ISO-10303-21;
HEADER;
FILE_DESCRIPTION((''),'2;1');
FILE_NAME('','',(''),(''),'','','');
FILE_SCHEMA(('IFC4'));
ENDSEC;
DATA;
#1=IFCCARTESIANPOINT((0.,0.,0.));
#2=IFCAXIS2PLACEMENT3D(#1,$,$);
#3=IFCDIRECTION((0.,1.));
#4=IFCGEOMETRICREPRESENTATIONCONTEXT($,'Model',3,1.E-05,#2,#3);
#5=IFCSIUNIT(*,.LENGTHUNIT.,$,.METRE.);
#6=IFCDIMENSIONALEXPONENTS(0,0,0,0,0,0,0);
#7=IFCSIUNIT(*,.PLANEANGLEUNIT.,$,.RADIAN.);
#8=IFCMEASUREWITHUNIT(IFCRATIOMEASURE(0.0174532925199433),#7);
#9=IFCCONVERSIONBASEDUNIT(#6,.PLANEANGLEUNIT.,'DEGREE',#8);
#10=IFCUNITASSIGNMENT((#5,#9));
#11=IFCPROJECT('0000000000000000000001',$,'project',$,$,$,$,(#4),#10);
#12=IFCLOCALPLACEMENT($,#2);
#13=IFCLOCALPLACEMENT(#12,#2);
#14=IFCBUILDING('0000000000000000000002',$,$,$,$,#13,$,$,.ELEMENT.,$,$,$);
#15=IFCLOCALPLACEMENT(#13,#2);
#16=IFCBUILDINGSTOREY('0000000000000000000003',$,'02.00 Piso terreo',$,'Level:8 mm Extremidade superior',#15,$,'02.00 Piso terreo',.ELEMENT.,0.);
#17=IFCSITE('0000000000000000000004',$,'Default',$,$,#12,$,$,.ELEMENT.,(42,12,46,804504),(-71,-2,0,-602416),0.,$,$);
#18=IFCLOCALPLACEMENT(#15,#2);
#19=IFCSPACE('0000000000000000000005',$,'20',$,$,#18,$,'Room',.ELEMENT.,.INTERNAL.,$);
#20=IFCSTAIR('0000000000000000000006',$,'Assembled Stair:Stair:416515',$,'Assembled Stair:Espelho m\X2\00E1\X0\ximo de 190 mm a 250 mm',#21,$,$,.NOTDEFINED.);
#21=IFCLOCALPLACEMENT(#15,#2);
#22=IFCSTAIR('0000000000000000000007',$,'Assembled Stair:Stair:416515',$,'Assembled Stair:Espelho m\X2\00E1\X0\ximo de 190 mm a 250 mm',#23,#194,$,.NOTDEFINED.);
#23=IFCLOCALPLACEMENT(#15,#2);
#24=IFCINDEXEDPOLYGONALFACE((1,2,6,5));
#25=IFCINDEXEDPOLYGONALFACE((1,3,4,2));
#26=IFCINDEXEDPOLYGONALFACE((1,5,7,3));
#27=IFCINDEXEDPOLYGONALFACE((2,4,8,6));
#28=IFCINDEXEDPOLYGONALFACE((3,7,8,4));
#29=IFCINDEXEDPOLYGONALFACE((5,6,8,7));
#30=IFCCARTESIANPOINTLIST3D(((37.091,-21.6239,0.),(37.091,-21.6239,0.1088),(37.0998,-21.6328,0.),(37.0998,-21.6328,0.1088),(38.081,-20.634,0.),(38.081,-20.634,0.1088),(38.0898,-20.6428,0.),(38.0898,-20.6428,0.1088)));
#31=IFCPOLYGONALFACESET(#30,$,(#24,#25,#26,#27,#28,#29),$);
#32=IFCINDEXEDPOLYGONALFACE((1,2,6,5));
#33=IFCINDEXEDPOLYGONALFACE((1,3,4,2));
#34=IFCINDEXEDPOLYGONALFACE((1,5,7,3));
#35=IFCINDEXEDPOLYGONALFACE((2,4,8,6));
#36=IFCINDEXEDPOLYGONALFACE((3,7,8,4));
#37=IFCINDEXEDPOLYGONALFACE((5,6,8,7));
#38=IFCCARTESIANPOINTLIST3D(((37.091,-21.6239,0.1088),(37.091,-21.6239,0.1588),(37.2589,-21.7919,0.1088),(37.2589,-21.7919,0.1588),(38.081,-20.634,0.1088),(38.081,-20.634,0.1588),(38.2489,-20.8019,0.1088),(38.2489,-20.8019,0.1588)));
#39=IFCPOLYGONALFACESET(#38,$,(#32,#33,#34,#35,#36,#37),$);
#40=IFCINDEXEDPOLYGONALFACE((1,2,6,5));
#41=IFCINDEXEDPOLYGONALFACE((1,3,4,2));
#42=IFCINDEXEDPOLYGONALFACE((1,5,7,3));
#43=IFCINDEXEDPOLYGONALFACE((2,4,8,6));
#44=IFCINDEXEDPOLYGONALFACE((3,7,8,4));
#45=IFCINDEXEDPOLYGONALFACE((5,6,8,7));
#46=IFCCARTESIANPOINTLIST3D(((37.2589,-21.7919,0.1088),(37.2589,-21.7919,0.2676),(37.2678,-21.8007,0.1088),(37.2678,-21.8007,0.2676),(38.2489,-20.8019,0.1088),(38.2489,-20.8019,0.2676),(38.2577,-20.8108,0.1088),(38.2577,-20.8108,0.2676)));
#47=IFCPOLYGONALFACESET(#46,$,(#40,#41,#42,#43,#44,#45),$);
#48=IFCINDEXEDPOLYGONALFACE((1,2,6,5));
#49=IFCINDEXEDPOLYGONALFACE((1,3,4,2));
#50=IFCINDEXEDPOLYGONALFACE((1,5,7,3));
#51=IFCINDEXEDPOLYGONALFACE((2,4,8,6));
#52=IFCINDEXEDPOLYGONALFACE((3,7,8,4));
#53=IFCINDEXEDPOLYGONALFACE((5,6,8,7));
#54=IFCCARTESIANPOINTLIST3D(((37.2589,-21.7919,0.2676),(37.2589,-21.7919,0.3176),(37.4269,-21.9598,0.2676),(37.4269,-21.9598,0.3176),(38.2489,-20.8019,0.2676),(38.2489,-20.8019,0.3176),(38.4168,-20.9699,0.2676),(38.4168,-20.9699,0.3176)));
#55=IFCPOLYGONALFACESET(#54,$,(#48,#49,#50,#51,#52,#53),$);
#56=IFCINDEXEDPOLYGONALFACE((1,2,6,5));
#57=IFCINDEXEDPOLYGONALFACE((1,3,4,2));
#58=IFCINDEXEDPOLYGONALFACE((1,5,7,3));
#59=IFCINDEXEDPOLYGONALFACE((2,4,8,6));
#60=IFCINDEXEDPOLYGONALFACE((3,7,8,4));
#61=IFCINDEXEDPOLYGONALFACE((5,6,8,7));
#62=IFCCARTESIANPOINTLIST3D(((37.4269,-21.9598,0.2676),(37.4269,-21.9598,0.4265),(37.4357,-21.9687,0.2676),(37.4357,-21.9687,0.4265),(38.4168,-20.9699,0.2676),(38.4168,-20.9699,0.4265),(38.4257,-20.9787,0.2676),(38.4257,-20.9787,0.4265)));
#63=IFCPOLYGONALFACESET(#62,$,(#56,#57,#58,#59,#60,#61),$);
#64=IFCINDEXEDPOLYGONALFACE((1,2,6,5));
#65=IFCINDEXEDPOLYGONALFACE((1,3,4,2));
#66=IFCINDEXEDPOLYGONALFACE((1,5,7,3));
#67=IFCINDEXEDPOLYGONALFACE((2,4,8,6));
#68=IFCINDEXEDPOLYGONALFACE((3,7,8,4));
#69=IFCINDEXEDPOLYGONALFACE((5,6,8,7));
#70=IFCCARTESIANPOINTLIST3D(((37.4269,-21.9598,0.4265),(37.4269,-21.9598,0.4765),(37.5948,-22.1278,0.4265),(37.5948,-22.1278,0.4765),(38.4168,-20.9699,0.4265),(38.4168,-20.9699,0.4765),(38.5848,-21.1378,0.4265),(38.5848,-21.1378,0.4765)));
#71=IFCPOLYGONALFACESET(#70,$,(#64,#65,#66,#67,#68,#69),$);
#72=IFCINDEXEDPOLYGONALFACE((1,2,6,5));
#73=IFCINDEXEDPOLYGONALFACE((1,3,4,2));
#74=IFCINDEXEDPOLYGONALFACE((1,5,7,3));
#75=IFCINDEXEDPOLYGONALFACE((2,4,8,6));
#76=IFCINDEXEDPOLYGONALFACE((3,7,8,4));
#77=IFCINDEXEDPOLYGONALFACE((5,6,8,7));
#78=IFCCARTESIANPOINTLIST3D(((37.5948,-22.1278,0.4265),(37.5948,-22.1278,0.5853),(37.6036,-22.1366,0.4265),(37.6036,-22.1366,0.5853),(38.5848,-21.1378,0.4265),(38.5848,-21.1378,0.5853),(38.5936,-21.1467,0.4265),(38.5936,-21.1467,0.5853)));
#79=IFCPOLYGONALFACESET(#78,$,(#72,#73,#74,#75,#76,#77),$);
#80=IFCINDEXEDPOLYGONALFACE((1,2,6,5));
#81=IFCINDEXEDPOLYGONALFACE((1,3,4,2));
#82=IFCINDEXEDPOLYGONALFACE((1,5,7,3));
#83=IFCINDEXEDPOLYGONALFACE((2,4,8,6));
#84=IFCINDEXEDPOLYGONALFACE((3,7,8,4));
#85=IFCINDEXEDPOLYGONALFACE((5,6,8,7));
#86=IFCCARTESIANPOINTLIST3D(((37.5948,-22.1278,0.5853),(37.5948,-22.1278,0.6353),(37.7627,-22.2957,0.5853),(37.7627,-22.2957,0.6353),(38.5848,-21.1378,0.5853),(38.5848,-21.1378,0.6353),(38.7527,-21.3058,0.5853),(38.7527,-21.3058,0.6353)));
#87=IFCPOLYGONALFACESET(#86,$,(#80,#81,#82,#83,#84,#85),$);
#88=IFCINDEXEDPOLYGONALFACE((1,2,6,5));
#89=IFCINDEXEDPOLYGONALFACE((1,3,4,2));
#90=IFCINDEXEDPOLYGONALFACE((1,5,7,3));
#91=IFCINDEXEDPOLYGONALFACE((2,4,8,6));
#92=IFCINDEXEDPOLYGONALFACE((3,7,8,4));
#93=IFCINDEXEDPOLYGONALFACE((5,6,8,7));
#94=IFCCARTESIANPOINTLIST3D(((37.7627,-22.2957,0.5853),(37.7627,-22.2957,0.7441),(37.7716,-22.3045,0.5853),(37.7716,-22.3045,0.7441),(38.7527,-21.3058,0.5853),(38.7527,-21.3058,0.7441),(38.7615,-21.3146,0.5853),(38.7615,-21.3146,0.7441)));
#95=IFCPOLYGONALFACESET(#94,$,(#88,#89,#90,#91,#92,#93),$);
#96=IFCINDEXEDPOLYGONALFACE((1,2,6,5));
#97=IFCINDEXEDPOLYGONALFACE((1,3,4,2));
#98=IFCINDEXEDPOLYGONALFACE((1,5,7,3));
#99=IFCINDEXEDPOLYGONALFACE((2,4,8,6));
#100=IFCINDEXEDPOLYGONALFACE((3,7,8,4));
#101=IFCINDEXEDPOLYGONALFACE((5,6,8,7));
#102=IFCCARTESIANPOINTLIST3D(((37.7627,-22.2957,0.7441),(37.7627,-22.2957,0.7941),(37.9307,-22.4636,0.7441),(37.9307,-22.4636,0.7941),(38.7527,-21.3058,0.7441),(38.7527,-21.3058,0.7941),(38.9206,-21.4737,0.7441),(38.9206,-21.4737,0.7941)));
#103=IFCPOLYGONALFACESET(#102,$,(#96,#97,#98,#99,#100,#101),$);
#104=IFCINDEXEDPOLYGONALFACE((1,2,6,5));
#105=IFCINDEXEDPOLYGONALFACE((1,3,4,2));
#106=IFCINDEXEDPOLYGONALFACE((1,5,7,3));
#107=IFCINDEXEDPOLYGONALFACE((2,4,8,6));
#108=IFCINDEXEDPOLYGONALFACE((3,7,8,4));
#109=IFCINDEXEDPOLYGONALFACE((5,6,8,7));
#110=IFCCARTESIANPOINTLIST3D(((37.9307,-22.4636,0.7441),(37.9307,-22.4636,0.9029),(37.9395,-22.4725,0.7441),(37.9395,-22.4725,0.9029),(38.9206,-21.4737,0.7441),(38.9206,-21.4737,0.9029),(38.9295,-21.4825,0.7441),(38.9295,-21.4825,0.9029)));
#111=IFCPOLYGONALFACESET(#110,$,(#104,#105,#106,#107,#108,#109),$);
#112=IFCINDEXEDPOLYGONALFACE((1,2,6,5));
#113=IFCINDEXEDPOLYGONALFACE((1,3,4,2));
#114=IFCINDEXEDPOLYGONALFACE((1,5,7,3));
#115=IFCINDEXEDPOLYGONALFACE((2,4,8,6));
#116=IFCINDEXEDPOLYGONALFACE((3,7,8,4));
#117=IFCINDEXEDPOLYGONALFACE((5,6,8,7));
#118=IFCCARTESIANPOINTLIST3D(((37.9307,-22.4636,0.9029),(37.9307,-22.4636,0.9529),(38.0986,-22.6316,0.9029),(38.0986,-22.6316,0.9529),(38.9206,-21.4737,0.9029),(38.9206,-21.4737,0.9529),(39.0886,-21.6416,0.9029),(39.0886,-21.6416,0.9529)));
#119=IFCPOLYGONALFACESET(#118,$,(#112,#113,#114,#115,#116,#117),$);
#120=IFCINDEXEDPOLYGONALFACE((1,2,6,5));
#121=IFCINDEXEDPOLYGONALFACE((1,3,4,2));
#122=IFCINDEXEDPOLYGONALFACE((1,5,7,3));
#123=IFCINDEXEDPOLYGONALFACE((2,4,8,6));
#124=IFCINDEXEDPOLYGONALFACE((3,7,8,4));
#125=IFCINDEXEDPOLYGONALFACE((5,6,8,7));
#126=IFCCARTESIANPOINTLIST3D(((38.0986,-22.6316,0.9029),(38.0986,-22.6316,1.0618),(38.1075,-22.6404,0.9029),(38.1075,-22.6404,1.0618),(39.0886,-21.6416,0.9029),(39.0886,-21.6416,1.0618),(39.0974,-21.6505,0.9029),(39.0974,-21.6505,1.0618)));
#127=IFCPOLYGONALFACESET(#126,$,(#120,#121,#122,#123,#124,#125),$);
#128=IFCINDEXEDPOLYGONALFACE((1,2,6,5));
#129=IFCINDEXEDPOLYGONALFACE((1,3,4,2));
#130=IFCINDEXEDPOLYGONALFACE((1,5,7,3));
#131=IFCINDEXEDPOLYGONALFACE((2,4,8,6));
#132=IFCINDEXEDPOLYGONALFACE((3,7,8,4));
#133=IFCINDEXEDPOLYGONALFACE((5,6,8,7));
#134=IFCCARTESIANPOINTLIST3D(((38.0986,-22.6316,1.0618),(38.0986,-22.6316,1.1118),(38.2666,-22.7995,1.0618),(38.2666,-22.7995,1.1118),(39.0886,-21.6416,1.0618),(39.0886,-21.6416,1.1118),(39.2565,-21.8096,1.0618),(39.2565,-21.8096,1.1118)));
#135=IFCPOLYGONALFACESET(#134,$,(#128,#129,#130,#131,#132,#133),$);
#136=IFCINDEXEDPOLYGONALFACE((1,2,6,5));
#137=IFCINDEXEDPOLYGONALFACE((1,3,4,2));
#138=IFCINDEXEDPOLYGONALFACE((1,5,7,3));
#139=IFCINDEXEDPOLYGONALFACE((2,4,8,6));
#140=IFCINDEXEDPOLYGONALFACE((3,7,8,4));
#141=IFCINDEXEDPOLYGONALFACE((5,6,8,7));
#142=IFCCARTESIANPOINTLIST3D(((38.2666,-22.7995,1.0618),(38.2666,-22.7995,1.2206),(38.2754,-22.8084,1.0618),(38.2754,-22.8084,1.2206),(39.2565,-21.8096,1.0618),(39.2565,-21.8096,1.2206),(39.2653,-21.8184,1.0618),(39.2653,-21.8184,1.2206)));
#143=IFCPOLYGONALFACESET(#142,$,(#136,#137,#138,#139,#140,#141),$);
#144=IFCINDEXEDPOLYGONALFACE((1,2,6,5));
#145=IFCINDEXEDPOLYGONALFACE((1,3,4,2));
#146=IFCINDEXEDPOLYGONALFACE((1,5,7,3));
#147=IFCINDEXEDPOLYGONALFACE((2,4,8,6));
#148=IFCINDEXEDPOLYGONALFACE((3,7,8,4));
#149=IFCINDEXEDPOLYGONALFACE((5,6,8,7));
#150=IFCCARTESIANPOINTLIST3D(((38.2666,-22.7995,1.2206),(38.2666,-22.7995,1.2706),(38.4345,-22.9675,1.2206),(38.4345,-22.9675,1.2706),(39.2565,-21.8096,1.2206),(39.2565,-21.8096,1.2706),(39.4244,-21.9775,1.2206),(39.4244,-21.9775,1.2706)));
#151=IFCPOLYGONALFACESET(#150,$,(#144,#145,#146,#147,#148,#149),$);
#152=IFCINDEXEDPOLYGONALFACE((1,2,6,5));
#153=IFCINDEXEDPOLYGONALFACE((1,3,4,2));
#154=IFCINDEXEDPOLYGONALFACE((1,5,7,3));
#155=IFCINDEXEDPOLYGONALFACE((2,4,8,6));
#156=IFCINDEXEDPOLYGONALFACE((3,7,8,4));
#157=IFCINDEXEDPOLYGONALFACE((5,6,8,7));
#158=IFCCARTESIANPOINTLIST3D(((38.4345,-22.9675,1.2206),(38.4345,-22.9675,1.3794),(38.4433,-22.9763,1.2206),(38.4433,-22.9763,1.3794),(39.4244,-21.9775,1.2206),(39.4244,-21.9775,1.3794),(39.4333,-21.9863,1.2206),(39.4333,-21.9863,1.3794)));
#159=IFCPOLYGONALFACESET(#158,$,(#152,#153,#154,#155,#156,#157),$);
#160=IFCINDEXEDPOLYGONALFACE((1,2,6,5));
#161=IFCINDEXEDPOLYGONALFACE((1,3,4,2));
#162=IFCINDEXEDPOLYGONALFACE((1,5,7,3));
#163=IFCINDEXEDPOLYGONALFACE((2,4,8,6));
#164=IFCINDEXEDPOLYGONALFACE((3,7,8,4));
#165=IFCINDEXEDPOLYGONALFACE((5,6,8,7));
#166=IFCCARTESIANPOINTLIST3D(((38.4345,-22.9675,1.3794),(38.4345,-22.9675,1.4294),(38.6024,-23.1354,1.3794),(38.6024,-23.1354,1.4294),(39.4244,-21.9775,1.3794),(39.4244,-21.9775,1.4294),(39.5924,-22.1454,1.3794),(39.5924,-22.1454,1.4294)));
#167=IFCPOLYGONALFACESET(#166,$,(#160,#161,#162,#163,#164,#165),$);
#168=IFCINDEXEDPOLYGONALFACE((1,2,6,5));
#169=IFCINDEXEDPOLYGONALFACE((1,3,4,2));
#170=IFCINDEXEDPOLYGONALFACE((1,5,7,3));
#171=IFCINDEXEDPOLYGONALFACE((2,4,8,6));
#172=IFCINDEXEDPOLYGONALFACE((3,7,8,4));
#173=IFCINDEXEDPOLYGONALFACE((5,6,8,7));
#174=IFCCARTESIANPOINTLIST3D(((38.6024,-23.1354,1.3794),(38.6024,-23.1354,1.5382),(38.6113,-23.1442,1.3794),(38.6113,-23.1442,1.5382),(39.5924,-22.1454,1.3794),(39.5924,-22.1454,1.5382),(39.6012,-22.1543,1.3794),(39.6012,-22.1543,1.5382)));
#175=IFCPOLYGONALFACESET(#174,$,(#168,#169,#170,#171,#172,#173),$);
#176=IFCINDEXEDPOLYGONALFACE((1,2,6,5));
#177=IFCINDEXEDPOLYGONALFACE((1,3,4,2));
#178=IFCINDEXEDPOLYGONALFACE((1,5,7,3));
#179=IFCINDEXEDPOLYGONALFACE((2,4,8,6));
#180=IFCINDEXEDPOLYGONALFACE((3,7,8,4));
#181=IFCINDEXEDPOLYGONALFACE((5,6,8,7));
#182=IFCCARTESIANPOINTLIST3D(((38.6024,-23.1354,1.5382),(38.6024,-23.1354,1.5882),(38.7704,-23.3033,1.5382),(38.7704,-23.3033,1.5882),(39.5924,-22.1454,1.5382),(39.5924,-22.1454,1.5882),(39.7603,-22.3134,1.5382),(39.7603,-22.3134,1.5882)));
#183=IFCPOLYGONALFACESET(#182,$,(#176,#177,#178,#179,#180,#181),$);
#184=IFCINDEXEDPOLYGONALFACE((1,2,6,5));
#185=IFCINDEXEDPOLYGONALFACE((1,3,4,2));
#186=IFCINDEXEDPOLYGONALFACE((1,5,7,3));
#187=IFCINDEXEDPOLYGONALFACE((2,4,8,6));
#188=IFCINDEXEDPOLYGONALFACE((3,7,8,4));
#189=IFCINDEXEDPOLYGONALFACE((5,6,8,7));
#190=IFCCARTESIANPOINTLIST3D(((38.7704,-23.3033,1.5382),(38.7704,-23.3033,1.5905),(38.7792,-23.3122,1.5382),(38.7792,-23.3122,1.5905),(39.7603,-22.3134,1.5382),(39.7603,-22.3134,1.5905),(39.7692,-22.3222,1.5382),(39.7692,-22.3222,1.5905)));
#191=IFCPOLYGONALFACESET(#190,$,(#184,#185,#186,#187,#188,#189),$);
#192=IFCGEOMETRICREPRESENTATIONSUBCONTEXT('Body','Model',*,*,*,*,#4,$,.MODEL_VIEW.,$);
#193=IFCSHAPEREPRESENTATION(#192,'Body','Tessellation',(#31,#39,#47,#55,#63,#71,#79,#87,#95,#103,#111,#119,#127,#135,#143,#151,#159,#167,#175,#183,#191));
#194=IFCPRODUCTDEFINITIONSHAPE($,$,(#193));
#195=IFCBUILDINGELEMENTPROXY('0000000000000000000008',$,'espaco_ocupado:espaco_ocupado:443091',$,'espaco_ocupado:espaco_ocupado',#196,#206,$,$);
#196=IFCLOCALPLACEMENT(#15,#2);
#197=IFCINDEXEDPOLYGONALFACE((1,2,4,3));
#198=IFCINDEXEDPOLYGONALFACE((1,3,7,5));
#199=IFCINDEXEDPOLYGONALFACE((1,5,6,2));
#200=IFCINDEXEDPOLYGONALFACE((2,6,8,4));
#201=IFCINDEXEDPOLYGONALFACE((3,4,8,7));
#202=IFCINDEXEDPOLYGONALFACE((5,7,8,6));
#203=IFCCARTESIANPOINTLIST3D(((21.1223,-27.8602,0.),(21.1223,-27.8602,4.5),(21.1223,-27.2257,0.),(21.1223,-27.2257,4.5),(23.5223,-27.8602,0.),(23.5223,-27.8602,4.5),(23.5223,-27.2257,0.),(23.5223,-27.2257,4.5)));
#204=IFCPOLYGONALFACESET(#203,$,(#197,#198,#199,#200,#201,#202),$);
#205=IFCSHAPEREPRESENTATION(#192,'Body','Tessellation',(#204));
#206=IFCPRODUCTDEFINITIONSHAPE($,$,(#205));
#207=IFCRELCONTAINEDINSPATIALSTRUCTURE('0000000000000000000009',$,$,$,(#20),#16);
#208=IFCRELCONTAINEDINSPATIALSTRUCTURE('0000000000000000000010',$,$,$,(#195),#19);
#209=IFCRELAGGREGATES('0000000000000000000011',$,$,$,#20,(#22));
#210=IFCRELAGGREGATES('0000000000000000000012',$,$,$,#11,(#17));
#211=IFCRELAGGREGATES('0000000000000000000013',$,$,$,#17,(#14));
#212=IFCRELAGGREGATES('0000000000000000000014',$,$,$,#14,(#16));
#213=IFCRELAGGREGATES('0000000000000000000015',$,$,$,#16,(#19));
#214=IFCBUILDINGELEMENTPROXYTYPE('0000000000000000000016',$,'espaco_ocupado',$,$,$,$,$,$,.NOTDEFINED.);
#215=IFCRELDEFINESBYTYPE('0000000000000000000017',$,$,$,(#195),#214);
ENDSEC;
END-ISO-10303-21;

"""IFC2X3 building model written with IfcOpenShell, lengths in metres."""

from ifc_helpers import new_model, entity, si_unit, converted_unit, direction, frame, frame_2d, origin, origin_2d_with_axis, place, context, subcontext, project, spatial, rectangle, extrude, source, transform, mapped, type_object, type_shapes, element, aggregate, save


model = new_model("IFC2X3")

# Units and contexts
model_context = context("Model", 3, precision=1e-05, world=origin(), true_north=direction((0.0, 1.0)))
body_context = subcontext(model_context, "Body", "Model", "MODEL_VIEW")
ifc_project = project(units=[si_unit("LENGTHUNIT", "METRE"), converted_unit("PLANEANGLEUNIT", "DEGREE", entity("IfcRatioMeasure", 0.0174532925199433), si_unit("PLANEANGLEUNIT", "RADIAN"), dimensions=[0, 0, 0, 0, 0, 0, 0])], contexts=[model_context])

# Site, building, storey
site_placement = place(None, origin())
site = spatial("IfcSite", under=ifc_project, at=site_placement, Name="Default", CompositionType="ELEMENT", RefLatitude=(42, 12, 46, 804504), RefLongitude=(-71, -2, 0, -602416), RefElevation=0.0)
building_placement = place(site_placement, origin())
building = spatial("IfcBuilding", under=site, at=building_placement, CompositionType="ELEMENT")
storey_placement = place(building_placement, origin())
storey = spatial("IfcBuildingStorey", under=building, at=storey_placement, Name="02.00 Piso terreo", ObjectType="Level:8 mm Extremidade superior", LongName="02.00 Piso terreo", CompositionType="ELEMENT", Elevation=0.0)

# Stairs
stair_1_placement = place(storey_placement, frame((37.091, -23.3122, 0.0)))
stair_1 = element("IfcStair", 1, at=stair_1_placement, inside=storey, Name="Assembled Stair:Stair:416515", ObjectType="Assembled Stair:Espelho máximo de 190 mm a 250 mm", ShapeType="NOTDEFINED")
stair_2_placement = place(stair_1_placement, origin())
stair_2 = element("IfcStair", 2, at=stair_2_placement, Name="Assembled Stair:Stair:416515", ObjectType="Assembled Stair:Espelho máximo de 190 mm a 250 mm", ShapeType="NOTDEFINED", context=body_context, shape_type="SweptSolid", body=[
    extrude(rectangle(XDim=1.4, YDim=0.0125, at=frame_2d((0.0, 0.0), x_axis=(1.0, 0.0))), frame((0.4994, 2.1788, 0.0), z_axis=(0.0, 0.0, 1.0), x_axis=(0.707111, 0.707103, 0.0)), (0.0, 0.0, 1.0), 0.1088),
    extrude(rectangle(XDim=0.2375, YDim=1.4, at=frame_2d((0.0, 0.0), x_axis=(1.0, 0.0))), frame((0.5789, 2.0992, 0.1088), z_axis=(0.0, 0.0, 1.0), x_axis=(-0.707103, 0.707111, 0.0)), (0.0, 0.0, 1.0), 0.05),
    extrude(rectangle(XDim=1.4, YDim=0.0125, at=frame_2d((0.0, 0.0), x_axis=(1.0, 0.0))), frame((0.6673, 2.0108, 0.1088), z_axis=(0.0, 0.0, 1.0), x_axis=(0.707111, 0.707103, 0.0)), (0.0, 0.0, 1.0), 0.1588),
    extrude(rectangle(XDim=0.2375, YDim=1.4, at=frame_2d((0.0, 0.0), x_axis=(1.0, 0.0))), frame((0.7469, 1.9313, 0.2676), z_axis=(0.0, 0.0, 1.0), x_axis=(-0.707103, 0.707111, 0.0)), (0.0, 0.0, 1.0), 0.05),
    extrude(rectangle(XDim=1.4, YDim=0.0125, at=frame_2d((0.0, 0.0), x_axis=(1.0, 0.0))), frame((0.8353, 1.8429, 0.2676), z_axis=(0.0, 0.0, 1.0), x_axis=(0.707111, 0.707103, 0.0)), (0.0, 0.0, 1.0), 0.1588),
    extrude(rectangle(XDim=0.2375, YDim=1.4, at=frame_2d((0.0, 0.0), x_axis=(1.0, 0.0))), frame((0.9148, 1.7634, 0.4265), z_axis=(0.0, 0.0, 1.0), x_axis=(-0.707103, 0.707111, 0.0)), (0.0, 0.0, 1.0), 0.05),
    extrude(rectangle(XDim=1.4, YDim=0.0125, at=frame_2d((0.0, 0.0), x_axis=(1.0, 0.0))), frame((1.0032, 1.675, 0.4265), z_axis=(0.0, 0.0, 1.0), x_axis=(0.707111, 0.707103, 0.0)), (0.0, 0.0, 1.0), 0.1588),
    extrude(rectangle(XDim=0.2375, YDim=1.4, at=frame_2d((0.0, 0.0), x_axis=(1.0, 0.0))), frame((1.0828, 1.5954, 0.5853), z_axis=(0.0, 0.0, 1.0), x_axis=(-0.707103, 0.707111, 0.0)), (0.0, 0.0, 1.0), 0.05),
    extrude(rectangle(XDim=1.4, YDim=0.0125, at=frame_2d((0.0, 0.0), x_axis=(1.0, 0.0))), frame((1.1711, 1.507, 0.5853), z_axis=(0.0, 0.0, 1.0), x_axis=(0.707111, 0.707103, 0.0)), (0.0, 0.0, 1.0), 0.1588),
    extrude(rectangle(XDim=0.2375, YDim=1.4, at=frame_2d((0.0, 0.0), x_axis=(1.0, 0.0))), frame((1.2507, 1.4275, 0.7441), z_axis=(0.0, 0.0, 1.0), x_axis=(-0.707103, 0.707111, 0.0)), (0.0, 0.0, 1.0), 0.05),
    extrude(rectangle(XDim=1.4, YDim=0.0125, at=frame_2d((0.0, 0.0), x_axis=(1.0, 0.0))), frame((1.3391, 1.3391, 0.7441), z_axis=(0.0, 0.0, 1.0), x_axis=(0.707111, 0.707103, 0.0)), (0.0, 0.0, 1.0), 0.1588),
    extrude(rectangle(XDim=0.2375, YDim=1.4, at=frame_2d((0.0, 0.0), x_axis=(1.0, 0.0))), frame((1.4186, 1.2595, 0.9029), z_axis=(0.0, 0.0, 1.0), x_axis=(-0.707103, 0.707111, 0.0)), (0.0, 0.0, 1.0), 0.05),
    extrude(rectangle(XDim=1.4, YDim=0.0125, at=frame_2d((0.0, 0.0), x_axis=(1.0, 0.0))), frame((1.507, 1.1711, 0.9029), z_axis=(0.0, 0.0, 1.0), x_axis=(0.707111, 0.707103, 0.0)), (0.0, 0.0, 1.0), 0.1588),
    extrude(rectangle(XDim=0.2375, YDim=1.4, at=frame_2d((0.0, 0.0), x_axis=(1.0, 0.0))), frame((1.5866, 1.0916, 1.0618), z_axis=(0.0, 0.0, 1.0), x_axis=(-0.707103, 0.707111, 0.0)), (0.0, 0.0, 1.0), 0.05),
    extrude(rectangle(XDim=1.4, YDim=0.0125, at=frame_2d((0.0, 0.0), x_axis=(1.0, 0.0))), frame((1.675, 1.0032, 1.0618), z_axis=(0.0, 0.0, 1.0), x_axis=(0.707111, 0.707103, 0.0)), (0.0, 0.0, 1.0), 0.1588),
    extrude(rectangle(XDim=0.2375, YDim=1.4, at=frame_2d((0.0, 0.0), x_axis=(1.0, 0.0))), frame((1.7545, 0.9237, 1.2206), z_axis=(0.0, 0.0, 1.0), x_axis=(-0.707103, 0.707111, 0.0)), (0.0, 0.0, 1.0), 0.05),
    extrude(rectangle(XDim=1.4, YDim=0.0125, at=frame_2d((0.0, 0.0), x_axis=(1.0, 0.0))), frame((1.8429, 0.8353, 1.2206), z_axis=(0.0, 0.0, 1.0), x_axis=(0.707111, 0.707103, 0.0)), (0.0, 0.0, 1.0), 0.1588),
    extrude(rectangle(XDim=0.2375, YDim=1.4, at=frame_2d((0.0, 0.0), x_axis=(1.0, 0.0))), frame((1.9224, 0.7557, 1.3794), z_axis=(0.0, 0.0, 1.0), x_axis=(-0.707103, 0.707111, 0.0)), (0.0, 0.0, 1.0), 0.05),
    extrude(rectangle(XDim=1.4, YDim=0.0125, at=frame_2d((0.0, 0.0), x_axis=(1.0, 0.0))), frame((2.0108, 0.6673, 1.3794), z_axis=(0.0, 0.0, 1.0), x_axis=(0.707111, 0.707103, 0.0)), (0.0, 0.0, 1.0), 0.1588),
    extrude(rectangle(XDim=0.2375, YDim=1.4, at=frame_2d((0.0, 0.0), x_axis=(1.0, 0.0))), frame((2.0904, 0.5878, 1.5382), z_axis=(0.0, 0.0, 1.0), x_axis=(-0.707103, 0.707111, 0.0)), (0.0, 0.0, 1.0), 0.05),
    extrude(rectangle(XDim=1.4, YDim=0.0125, at=frame_2d((0.0, 0.0), x_axis=(1.0, 0.0))), frame((2.1788, 0.4994, 1.5382), z_axis=(0.0, 0.0, 1.0), x_axis=(0.707111, 0.707103, 0.0)), (0.0, 0.0, 1.0), 0.0522),
])
aggregate(stair_1, [stair_2])

# Shared definitions
space_1_placement = place(storey_placement, origin())
space_1 = spatial("IfcSpace", under=storey, at=space_1_placement, Name="20", LongName="Room", CompositionType="ELEMENT", InteriorOrExteriorSpace="INTERNAL")

# Building element proxy
building_element_proxy_type_1 = type_object("IfcBuildingElementProxyType", Name="espaco_ocupado", PredefinedType="NOTDEFINED")
shared_shape_1 = source(origin(), body_context, "Body", "SweptSolid", [
    extrude(rectangle(XDim=2.4, YDim=0.6345, at=origin_2d_with_axis()), frame((0.0, 0.0, 0.0), z_axis=(0.0, 0.0, 1.0), x_axis=(-1.0, 0.0, 0.0)), (0.0, 0.0, 1.0), 4.5),
])
type_shapes(building_element_proxy_type_1, [shared_shape_1])
proxy_1_placement = place(space_1_placement, frame((22.3223, -27.5429, 0.0)))
element("IfcBuildingElementProxy", 3, at=proxy_1_placement, inside=space_1, type_object=building_element_proxy_type_1, Name="espaco_ocupado:espaco_ocupado:443091", ObjectType="espaco_ocupado:espaco_ocupado", context=body_context, shape_type="MappedRepresentation", body=[
    mapped(shared_shape_1, transform((0.0, 0.0, 0.0), scale=1.0)),
])

save(model, "model.ifc")
